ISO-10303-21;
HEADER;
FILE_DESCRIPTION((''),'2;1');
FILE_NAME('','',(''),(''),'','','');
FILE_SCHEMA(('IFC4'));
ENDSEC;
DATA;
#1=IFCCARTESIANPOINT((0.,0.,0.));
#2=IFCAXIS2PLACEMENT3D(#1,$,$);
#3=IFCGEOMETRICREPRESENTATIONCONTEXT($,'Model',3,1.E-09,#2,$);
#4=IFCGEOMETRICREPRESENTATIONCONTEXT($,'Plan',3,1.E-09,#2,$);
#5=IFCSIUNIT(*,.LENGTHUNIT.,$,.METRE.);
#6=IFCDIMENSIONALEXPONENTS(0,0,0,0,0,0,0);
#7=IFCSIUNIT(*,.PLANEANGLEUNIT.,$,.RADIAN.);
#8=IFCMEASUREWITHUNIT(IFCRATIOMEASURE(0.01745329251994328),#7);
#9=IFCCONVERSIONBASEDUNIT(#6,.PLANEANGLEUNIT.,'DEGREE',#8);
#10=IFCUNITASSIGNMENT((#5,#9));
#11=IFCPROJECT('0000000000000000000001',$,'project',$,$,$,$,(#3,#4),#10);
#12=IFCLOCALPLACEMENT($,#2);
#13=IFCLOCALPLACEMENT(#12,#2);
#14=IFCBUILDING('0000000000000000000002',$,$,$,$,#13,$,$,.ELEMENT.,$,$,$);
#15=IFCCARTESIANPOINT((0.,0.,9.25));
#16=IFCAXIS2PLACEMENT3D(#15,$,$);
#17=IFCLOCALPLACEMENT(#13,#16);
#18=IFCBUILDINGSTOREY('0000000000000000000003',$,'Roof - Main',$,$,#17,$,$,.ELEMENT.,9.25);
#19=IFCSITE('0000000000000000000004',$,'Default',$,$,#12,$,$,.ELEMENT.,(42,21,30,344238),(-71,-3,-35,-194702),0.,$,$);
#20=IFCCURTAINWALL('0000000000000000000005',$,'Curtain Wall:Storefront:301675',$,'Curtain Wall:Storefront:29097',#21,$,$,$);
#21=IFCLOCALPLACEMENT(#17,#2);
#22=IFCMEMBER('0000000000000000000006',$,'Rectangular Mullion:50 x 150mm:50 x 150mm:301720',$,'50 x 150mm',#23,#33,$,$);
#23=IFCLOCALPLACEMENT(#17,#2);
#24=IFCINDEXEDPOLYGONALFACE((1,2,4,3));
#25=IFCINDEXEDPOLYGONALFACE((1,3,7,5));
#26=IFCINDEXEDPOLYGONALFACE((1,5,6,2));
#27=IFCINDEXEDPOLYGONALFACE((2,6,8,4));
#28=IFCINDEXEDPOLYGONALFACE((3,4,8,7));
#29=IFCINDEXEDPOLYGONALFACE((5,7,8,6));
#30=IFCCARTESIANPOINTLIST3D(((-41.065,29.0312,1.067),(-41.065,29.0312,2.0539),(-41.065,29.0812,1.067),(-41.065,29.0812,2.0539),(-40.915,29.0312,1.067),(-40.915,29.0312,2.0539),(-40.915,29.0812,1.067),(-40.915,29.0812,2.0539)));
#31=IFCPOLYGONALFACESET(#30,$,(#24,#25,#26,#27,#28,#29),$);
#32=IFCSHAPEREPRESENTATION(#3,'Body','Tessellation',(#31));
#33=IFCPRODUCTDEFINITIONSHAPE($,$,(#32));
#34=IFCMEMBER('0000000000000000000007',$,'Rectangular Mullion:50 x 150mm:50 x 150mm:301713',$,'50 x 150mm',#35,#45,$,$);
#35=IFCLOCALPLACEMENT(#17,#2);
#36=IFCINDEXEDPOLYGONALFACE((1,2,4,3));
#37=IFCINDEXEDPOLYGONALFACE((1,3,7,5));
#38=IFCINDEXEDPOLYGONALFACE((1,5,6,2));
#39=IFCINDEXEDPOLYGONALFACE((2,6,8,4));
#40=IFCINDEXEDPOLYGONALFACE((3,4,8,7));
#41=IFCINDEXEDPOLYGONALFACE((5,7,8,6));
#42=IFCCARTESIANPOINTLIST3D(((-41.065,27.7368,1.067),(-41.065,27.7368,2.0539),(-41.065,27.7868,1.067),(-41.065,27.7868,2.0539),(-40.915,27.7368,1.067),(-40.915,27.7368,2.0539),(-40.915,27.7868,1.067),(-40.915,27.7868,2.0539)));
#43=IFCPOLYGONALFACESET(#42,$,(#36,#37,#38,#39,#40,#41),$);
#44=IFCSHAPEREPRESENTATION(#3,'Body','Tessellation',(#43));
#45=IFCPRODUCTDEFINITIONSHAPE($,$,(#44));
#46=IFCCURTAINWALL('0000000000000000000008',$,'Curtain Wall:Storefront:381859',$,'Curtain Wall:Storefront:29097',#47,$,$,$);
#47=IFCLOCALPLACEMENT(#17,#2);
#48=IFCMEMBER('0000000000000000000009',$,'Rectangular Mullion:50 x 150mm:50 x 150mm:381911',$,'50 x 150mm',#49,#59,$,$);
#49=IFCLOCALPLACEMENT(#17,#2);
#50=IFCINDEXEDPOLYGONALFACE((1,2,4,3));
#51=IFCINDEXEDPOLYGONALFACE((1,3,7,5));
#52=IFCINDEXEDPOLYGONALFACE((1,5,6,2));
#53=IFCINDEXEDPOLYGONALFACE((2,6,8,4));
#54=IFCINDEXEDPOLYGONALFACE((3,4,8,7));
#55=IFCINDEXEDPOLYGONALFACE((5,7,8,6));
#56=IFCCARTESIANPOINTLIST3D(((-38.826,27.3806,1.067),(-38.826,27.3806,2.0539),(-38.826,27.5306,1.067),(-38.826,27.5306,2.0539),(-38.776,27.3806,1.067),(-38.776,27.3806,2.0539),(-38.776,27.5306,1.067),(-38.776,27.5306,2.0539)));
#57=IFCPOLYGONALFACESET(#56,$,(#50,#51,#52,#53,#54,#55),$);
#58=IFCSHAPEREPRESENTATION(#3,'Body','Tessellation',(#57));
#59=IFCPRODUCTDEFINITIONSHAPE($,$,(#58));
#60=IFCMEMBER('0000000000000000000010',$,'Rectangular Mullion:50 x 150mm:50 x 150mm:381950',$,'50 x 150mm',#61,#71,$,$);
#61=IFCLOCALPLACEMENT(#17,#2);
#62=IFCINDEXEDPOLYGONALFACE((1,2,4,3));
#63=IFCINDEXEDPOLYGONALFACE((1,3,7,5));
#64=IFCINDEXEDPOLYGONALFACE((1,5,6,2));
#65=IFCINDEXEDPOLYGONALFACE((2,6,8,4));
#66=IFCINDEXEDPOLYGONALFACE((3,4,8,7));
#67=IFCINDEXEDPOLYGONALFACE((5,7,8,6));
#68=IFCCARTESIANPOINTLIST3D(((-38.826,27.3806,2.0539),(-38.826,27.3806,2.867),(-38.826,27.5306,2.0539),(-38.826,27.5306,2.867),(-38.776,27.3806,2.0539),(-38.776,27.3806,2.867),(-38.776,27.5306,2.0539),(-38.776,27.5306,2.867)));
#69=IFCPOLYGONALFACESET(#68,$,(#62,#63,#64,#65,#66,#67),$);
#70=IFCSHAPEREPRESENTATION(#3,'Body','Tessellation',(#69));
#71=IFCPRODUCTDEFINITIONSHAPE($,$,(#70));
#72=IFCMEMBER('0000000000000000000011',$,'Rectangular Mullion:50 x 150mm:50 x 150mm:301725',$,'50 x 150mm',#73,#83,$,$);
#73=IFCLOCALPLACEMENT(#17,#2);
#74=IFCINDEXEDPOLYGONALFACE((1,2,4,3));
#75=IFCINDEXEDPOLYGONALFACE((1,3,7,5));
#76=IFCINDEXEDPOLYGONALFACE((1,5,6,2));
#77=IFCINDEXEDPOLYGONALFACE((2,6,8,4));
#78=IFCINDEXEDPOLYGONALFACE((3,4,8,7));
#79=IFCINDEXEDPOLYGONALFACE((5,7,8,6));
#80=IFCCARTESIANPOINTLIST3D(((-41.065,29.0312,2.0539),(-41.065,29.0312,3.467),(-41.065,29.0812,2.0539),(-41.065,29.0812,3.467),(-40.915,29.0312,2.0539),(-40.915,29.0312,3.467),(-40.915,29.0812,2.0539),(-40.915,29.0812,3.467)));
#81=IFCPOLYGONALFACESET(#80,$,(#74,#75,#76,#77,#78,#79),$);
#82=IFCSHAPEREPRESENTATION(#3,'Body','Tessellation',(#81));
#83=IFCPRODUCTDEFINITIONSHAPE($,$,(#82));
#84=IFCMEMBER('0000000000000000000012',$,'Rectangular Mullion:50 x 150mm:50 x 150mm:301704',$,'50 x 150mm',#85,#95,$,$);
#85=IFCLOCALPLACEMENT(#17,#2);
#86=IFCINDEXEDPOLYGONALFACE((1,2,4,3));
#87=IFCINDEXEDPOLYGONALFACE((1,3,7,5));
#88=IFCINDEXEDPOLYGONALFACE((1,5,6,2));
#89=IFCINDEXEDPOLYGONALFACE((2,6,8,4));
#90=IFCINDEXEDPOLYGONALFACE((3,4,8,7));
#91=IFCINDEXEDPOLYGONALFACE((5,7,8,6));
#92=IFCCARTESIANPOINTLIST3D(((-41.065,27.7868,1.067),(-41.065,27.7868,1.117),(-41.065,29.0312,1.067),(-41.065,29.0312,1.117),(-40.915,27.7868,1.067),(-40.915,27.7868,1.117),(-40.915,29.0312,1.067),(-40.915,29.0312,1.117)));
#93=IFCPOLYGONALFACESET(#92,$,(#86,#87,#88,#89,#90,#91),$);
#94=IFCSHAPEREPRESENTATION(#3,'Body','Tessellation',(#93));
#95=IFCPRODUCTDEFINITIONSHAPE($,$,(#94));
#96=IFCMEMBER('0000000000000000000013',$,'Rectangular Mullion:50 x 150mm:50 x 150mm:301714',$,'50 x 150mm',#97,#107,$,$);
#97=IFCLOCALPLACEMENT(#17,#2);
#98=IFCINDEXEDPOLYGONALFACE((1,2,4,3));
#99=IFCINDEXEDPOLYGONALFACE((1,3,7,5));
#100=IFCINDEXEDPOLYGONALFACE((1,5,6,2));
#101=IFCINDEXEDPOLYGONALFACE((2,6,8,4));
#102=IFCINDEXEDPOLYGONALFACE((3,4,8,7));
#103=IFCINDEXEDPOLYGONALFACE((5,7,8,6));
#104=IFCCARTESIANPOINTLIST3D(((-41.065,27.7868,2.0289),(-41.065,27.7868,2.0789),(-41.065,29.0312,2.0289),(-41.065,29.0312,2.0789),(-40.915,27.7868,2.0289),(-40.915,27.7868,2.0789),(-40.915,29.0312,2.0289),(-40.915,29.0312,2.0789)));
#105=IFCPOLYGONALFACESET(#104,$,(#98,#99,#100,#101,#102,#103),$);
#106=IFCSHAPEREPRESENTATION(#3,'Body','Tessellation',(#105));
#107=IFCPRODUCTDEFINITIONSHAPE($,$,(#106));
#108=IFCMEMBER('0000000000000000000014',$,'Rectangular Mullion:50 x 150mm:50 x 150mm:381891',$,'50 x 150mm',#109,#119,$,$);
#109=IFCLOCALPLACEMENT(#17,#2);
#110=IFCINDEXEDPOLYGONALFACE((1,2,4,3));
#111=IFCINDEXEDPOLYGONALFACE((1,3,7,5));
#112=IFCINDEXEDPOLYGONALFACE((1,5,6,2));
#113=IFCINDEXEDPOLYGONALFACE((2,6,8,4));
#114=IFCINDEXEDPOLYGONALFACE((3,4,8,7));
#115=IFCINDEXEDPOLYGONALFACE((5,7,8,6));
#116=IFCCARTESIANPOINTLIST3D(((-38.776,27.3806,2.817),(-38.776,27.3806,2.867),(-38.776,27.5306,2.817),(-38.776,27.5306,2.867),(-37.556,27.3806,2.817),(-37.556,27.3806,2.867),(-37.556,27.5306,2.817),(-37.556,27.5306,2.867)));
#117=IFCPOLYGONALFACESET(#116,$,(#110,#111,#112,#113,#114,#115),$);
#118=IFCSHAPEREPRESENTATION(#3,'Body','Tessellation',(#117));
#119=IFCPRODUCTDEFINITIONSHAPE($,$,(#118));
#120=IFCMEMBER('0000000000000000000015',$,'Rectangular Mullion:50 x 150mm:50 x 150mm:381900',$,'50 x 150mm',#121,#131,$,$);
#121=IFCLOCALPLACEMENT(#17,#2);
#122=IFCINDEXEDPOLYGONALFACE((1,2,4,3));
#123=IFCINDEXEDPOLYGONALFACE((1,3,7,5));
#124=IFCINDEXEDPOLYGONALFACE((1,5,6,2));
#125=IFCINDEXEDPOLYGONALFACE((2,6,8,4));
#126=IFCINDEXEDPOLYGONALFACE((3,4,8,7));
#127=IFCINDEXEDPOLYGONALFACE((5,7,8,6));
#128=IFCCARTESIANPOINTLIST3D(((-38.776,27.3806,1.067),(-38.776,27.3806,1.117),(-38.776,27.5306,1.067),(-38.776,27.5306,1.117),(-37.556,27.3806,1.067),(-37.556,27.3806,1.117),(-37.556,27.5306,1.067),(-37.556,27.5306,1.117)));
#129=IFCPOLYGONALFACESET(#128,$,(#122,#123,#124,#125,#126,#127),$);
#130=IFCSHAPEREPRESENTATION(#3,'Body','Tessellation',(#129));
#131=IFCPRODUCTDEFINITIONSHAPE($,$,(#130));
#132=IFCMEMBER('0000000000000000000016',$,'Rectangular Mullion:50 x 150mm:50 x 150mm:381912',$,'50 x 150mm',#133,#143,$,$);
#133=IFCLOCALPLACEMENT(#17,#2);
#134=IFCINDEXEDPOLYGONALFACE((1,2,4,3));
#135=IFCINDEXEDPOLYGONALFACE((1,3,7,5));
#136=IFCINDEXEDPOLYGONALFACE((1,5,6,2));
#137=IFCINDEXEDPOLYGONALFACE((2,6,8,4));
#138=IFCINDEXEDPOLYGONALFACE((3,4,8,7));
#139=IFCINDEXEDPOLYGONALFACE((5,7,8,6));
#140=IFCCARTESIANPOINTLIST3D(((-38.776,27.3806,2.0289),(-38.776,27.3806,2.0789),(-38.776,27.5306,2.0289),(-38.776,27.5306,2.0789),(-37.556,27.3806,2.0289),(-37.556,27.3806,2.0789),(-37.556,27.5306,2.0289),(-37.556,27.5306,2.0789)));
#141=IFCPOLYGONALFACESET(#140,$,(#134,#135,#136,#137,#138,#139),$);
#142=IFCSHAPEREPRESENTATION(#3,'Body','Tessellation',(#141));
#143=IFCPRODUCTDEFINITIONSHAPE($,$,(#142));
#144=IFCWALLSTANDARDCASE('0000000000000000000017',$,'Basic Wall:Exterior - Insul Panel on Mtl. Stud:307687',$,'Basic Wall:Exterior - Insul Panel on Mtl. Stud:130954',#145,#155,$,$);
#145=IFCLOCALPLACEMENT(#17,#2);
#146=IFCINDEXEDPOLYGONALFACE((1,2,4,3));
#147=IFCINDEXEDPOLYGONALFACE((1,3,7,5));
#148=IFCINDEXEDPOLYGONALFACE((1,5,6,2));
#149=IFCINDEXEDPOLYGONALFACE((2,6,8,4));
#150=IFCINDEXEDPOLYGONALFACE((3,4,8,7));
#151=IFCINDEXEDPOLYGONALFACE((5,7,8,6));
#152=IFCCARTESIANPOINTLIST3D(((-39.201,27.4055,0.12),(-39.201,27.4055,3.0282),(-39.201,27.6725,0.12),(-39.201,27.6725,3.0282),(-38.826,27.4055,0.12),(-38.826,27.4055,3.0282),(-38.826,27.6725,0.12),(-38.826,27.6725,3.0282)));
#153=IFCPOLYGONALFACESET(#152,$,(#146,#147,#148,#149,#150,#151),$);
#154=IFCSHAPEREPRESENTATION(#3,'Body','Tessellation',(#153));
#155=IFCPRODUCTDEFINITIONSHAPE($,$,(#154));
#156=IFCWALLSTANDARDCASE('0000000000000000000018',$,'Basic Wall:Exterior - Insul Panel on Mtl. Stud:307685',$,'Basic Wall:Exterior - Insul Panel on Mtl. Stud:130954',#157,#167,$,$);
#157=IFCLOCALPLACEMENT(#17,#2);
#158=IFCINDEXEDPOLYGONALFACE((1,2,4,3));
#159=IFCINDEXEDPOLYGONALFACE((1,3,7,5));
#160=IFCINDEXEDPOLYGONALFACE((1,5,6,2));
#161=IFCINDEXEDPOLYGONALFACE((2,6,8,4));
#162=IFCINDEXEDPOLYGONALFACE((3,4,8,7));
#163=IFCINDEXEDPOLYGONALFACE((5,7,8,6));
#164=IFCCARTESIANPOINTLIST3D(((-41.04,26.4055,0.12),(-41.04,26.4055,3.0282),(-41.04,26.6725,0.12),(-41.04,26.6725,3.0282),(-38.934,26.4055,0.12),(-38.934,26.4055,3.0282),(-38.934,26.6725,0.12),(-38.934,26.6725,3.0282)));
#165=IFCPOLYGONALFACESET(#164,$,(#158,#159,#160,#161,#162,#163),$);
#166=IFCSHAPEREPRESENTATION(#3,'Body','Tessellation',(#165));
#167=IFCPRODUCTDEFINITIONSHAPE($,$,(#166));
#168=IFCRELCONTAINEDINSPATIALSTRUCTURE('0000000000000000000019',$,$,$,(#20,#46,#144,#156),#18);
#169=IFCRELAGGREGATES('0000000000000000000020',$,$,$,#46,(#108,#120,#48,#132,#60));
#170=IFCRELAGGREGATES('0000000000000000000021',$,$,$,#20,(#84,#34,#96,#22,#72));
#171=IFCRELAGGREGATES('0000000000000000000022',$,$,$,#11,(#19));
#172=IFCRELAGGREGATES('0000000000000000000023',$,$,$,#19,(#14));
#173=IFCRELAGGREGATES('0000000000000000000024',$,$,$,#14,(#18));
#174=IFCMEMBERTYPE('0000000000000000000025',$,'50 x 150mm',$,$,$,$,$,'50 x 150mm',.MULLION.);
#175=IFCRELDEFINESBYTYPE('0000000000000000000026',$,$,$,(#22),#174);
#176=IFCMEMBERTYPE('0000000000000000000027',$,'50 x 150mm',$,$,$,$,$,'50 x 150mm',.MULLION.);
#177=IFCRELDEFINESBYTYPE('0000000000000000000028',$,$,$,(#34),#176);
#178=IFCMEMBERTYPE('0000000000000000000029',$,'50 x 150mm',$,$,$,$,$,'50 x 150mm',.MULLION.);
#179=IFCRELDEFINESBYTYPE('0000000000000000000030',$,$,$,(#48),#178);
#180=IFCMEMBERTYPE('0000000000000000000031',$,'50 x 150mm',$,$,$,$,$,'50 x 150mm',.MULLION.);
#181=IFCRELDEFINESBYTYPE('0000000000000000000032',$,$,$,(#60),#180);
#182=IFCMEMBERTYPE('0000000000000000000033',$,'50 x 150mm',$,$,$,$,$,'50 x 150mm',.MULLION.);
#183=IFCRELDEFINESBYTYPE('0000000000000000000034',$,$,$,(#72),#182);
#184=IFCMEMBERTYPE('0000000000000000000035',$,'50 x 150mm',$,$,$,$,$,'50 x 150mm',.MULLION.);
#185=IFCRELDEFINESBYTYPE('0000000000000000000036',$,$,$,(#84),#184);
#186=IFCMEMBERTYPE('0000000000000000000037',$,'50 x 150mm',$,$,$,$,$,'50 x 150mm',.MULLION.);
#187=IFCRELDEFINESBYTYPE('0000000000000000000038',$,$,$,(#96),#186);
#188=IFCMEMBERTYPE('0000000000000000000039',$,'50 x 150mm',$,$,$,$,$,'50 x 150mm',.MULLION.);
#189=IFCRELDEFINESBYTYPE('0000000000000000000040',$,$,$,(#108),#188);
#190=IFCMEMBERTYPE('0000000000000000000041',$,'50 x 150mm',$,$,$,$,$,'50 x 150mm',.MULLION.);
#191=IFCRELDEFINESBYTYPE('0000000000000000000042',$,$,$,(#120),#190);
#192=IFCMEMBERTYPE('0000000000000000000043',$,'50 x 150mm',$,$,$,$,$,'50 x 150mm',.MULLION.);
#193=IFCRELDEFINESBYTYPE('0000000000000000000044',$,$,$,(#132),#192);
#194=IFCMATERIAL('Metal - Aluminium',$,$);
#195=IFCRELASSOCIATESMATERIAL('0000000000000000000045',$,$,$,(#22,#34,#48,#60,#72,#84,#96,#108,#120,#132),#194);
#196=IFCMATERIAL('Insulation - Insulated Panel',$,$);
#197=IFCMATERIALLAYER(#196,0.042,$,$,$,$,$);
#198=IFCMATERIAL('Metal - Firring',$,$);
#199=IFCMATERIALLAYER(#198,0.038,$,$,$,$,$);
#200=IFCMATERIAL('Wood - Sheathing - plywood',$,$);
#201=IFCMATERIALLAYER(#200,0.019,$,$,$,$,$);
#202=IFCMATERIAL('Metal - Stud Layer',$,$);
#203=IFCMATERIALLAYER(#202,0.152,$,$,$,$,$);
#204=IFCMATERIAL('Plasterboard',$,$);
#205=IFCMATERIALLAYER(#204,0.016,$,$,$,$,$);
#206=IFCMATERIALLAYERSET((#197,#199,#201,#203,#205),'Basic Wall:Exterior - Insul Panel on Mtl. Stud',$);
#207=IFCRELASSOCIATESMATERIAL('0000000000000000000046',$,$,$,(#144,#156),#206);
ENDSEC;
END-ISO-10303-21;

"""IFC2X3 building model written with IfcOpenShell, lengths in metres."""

from ifc_helpers import new_model, entity, si_unit, converted_unit, frame, frame_2d, origin, origin_2d_with_axis, place, context, project, spatial, rectangle, extrude, source, transform, mapped, material, layer, layer_set, layer_usage, type_object, type_shapes, element, aggregate, save


model = new_model("IFC2X3")

# Units and contexts
model_context = context("Model", 3, precision=1e-09, world=origin())
plan_context = context("Plan", 3, precision=1e-09, world=origin())
ifc_project = project(units=[si_unit("LENGTHUNIT", "METRE"), converted_unit("PLANEANGLEUNIT", "DEGREE", entity("IfcRatioMeasure", 0.01745329251994328), si_unit("PLANEANGLEUNIT", "RADIAN"), dimensions=[0, 0, 0, 0, 0, 0, 0])], contexts=[model_context, plan_context])

# Site, building, storey
site_placement = place(None, origin())
site = spatial("IfcSite", under=ifc_project, at=site_placement, Name="Default", CompositionType="ELEMENT", RefLatitude=(42, 21, 30, 344238), RefLongitude=(-71, -3, -35, -194702), RefElevation=0.0)
building_placement = place(site_placement, origin())
building = spatial("IfcBuilding", under=site, at=building_placement, CompositionType="ELEMENT")
storey_placement = place(building_placement, frame((0.0, 0.0, 9.25)))
storey = spatial("IfcBuildingStorey", under=building, at=storey_placement, Name="Roof - Main", CompositionType="ELEMENT", Elevation=9.25)

# Curtain walls, members
curtain_wall_1_placement = place(storey_placement, origin())
curtain_wall_1 = element("IfcCurtainWall", 1, at=curtain_wall_1_placement, inside=storey, Name="Curtain Wall:Storefront:301675", ObjectType="Curtain Wall:Storefront:29097")
ifc_material_1 = material(Name="Metal - Aluminium")
member_type_1 = type_object("IfcMemberType", Name="50 x 150mm", ElementType="50 x 150mm", PredefinedType="MULLION")
shared_shape_1 = source(origin(), model_context, "Body", "SweptSolid", [
    extrude(rectangle(XDim=0.05, YDim=0.15, at=origin_2d_with_axis()), frame((0.0, 0.0, -0.9869), z_axis=(0.0, 0.0, 1.0), x_axis=(-1.0, 0.0, 0.0)), (0.0, 0.0, 1.0), 0.9869),
])
type_shapes(member_type_1, [shared_shape_1])
member_1_placement = place(storey_placement, frame((-40.99, 29.0562, 1.067), z_axis=(0.0, 0.0, -1.0), x_axis=(0.0, 1.0, 0.0)))
member_1 = element("IfcMember", 2, at=member_1_placement, type_object=member_type_1, material=ifc_material_1, Name="Rectangular Mullion:50 x 150mm:50 x 150mm:301720", ObjectType="50 x 150mm", context=model_context, shape_type="MappedRepresentation", body=[
    mapped(shared_shape_1, transform((0.0, 0.0, 0.0), scale=1.0)),
])
member_type_2 = type_object("IfcMemberType", Name="50 x 150mm", ElementType="50 x 150mm", PredefinedType="MULLION")
shared_shape_2 = source(origin(), model_context, "Body", "SweptSolid", [
    extrude(rectangle(XDim=0.05, YDim=0.15, at=origin_2d_with_axis()), frame((-0.025, 0.0, -0.9869), z_axis=(0.0, 0.0, 1.0), x_axis=(-1.0, 0.0, 0.0)), (0.0, 0.0, 1.0), 0.9869),
])
type_shapes(member_type_2, [shared_shape_2])
member_2_placement = place(storey_placement, frame((-40.99, 27.7368, 2.0539), z_axis=(0.0, 0.0, 1.0), x_axis=(0.0, -1.0, 0.0)))
member_2 = element("IfcMember", 3, at=member_2_placement, type_object=member_type_2, material=ifc_material_1, Name="Rectangular Mullion:50 x 150mm:50 x 150mm:301713", ObjectType="50 x 150mm", context=model_context, shape_type="MappedRepresentation", body=[
    mapped(shared_shape_2, transform((0.0, 0.0, 0.0), scale=1.0)),
])
curtain_wall_2_placement = place(storey_placement, origin())
curtain_wall_2 = element("IfcCurtainWall", 4, at=curtain_wall_2_placement, inside=storey, Name="Curtain Wall:Storefront:381859", ObjectType="Curtain Wall:Storefront:29097")
member_type_3 = type_object("IfcMemberType", Name="50 x 150mm", ElementType="50 x 150mm", PredefinedType="MULLION")
type_shapes(member_type_3, [shared_shape_2])
member_3_placement = place(storey_placement, frame((-38.826, 27.4556, 2.0539), z_axis=(0.0, 0.0, 1.0), x_axis=(-1.0, 0.0, 0.0)))
member_3 = element("IfcMember", 5, at=member_3_placement, type_object=member_type_3, material=ifc_material_1, Name="Rectangular Mullion:50 x 150mm:50 x 150mm:381911", ObjectType="50 x 150mm", context=model_context, shape_type="MappedRepresentation", body=[
    mapped(shared_shape_2, transform((0.0, 0.0, 0.0), scale=1.0)),
])
member_type_4 = type_object("IfcMemberType", Name="50 x 150mm", ElementType="50 x 150mm", PredefinedType="MULLION")
shared_shape_3 = source(origin(), model_context, "Body", "SweptSolid", [
    extrude(rectangle(XDim=0.05, YDim=0.15, at=origin_2d_with_axis()), frame((-0.025, 0.0, -0.8131), z_axis=(0.0, 0.0, 1.0), x_axis=(-1.0, 0.0, 0.0)), (0.0, 0.0, 1.0), 0.8131),
])
type_shapes(member_type_4, [shared_shape_3])
member_4_placement = place(storey_placement, frame((-38.826, 27.4556, 2.867), z_axis=(0.0, 0.0, 1.0), x_axis=(-1.0, 0.0, 0.0)))
member_4 = element("IfcMember", 6, at=member_4_placement, type_object=member_type_4, material=ifc_material_1, Name="Rectangular Mullion:50 x 150mm:50 x 150mm:381950", ObjectType="50 x 150mm", context=model_context, shape_type="MappedRepresentation", body=[
    mapped(shared_shape_3, transform((0.0, 0.0, 0.0), scale=1.0)),
])

# Members
member_type_5 = type_object("IfcMemberType", Name="50 x 150mm", ElementType="50 x 150mm", PredefinedType="MULLION")
shared_shape_4 = source(origin(), model_context, "Body", "SweptSolid", [
    extrude(rectangle(XDim=0.05, YDim=0.15, at=origin_2d_with_axis()), frame((0.0, 0.0, -1.4131), z_axis=(0.0, 0.0, 1.0), x_axis=(-1.0, 0.0, 0.0)), (0.0, 0.0, 1.0), 1.4131),
])
type_shapes(member_type_5, [shared_shape_4])
member_5_placement = place(storey_placement, frame((-40.99, 29.0562, 2.0539), z_axis=(0.0, 0.0, -1.0), x_axis=(0.0, 1.0, 0.0)))
member_5 = element("IfcMember", 7, at=member_5_placement, type_object=member_type_5, material=ifc_material_1, Name="Rectangular Mullion:50 x 150mm:50 x 150mm:301725", ObjectType="50 x 150mm", context=model_context, shape_type="MappedRepresentation", body=[
    mapped(shared_shape_4, transform((0.0, 0.0, 0.0), scale=1.0)),
])
member_type_6 = type_object("IfcMemberType", Name="50 x 150mm", ElementType="50 x 150mm", PredefinedType="MULLION")
shared_shape_5 = source(origin(), model_context, "Body", "SweptSolid", [
    extrude(rectangle(XDim=0.05, YDim=0.15, at=origin_2d_with_axis()), frame((-0.025, 0.0, -1.2444), z_axis=(0.0, 0.0, 1.0), x_axis=(-1.0, 0.0, 0.0)), (0.0, 0.0, 1.0), 1.2444),
])
type_shapes(member_type_6, [shared_shape_5])
member_6_placement = place(storey_placement, frame((-40.99, 27.7868, 1.067), z_axis=(0.0, -1.0, 0.0), x_axis=(0.0, 0.0, -1.0)))
member_6 = element("IfcMember", 8, at=member_6_placement, type_object=member_type_6, material=ifc_material_1, Name="Rectangular Mullion:50 x 150mm:50 x 150mm:301704", ObjectType="50 x 150mm", context=model_context, shape_type="MappedRepresentation", body=[
    mapped(shared_shape_5, transform((0.0, 0.0, 0.0), scale=1.0)),
])
member_type_7 = type_object("IfcMemberType", Name="50 x 150mm", ElementType="50 x 150mm", PredefinedType="MULLION")
shared_shape_6 = source(origin(), model_context, "Body", "SweptSolid", [
    extrude(rectangle(XDim=0.05, YDim=0.15, at=origin_2d_with_axis()), frame((0.0, 0.0, -1.2444), z_axis=(0.0, 0.0, 1.0), x_axis=(-1.0, 0.0, 0.0)), (0.0, 0.0, 1.0), 1.2444),
])
type_shapes(member_type_7, [shared_shape_6])
member_7_placement = place(storey_placement, frame((-40.99, 29.0312, 2.0539), z_axis=(0.0, 1.0, 0.0), x_axis=(0.0, 0.0, 1.0)))
member_7 = element("IfcMember", 9, at=member_7_placement, type_object=member_type_7, material=ifc_material_1, Name="Rectangular Mullion:50 x 150mm:50 x 150mm:301714", ObjectType="50 x 150mm", context=model_context, shape_type="MappedRepresentation", body=[
    mapped(shared_shape_6, transform((0.0, 0.0, 0.0), scale=1.0)),
])
member_type_8 = type_object("IfcMemberType", Name="50 x 150mm", ElementType="50 x 150mm", PredefinedType="MULLION")
shared_shape_7 = source(origin(), model_context, "Body", "SweptSolid", [
    extrude(rectangle(XDim=0.05, YDim=0.15, at=origin_2d_with_axis()), frame((-0.025, 0.0, -1.22), z_axis=(0.0, 0.0, 1.0), x_axis=(-1.0, 0.0, 0.0)), (0.0, 0.0, 1.0), 1.22),
])
type_shapes(member_type_8, [shared_shape_7])
member_8_placement = place(storey_placement, frame((-37.556, 27.4556, 2.867), z_axis=(1.0, 0.0, 0.0), x_axis=(0.0, 0.0, 1.0)))
member_8 = element("IfcMember", 10, at=member_8_placement, type_object=member_type_8, material=ifc_material_1, Name="Rectangular Mullion:50 x 150mm:50 x 150mm:381891", ObjectType="50 x 150mm", context=model_context, shape_type="MappedRepresentation", body=[
    mapped(shared_shape_7, transform((0.0, 0.0, 0.0), scale=1.0)),
])
member_type_9 = type_object("IfcMemberType", Name="50 x 150mm", ElementType="50 x 150mm", PredefinedType="MULLION")
shared_shape_8 = source(origin(), model_context, "Body", "SweptSolid", [
    extrude(rectangle(XDim=0.05, YDim=0.15, at=origin_2d_with_axis()), frame((-0.025, 0.0, -1.22), z_axis=(0.0, 0.0, 1.0), x_axis=(-1.0, 0.0, 0.0)), (0.0, 0.0, 1.0), 1.22),
])
type_shapes(member_type_9, [shared_shape_8])
member_9_placement = place(storey_placement, frame((-38.776, 27.4556, 1.067), z_axis=(-1.0, 0.0, 0.0), x_axis=(0.0, 0.0, -1.0)))
member_9 = element("IfcMember", 11, at=member_9_placement, type_object=member_type_9, material=ifc_material_1, Name="Rectangular Mullion:50 x 150mm:50 x 150mm:381900", ObjectType="50 x 150mm", context=model_context, shape_type="MappedRepresentation", body=[
    mapped(shared_shape_8, transform((0.0, 0.0, 0.0), scale=1.0)),
])
member_type_10 = type_object("IfcMemberType", Name="50 x 150mm", ElementType="50 x 150mm", PredefinedType="MULLION")
shared_shape_9 = source(origin(), model_context, "Body", "SweptSolid", [
    extrude(rectangle(XDim=0.05, YDim=0.15, at=origin_2d_with_axis()), frame((0.0, 0.0, -1.22), z_axis=(0.0, 0.0, 1.0), x_axis=(-1.0, 0.0, 0.0)), (0.0, 0.0, 1.0), 1.22),
])
type_shapes(member_type_10, [shared_shape_9])
member_10_placement = place(storey_placement, frame((-37.556, 27.4556, 2.0539), z_axis=(1.0, 0.0, 0.0), x_axis=(0.0, 0.0, 1.0)))
member_10 = element("IfcMember", 12, at=member_10_placement, type_object=member_type_10, material=ifc_material_1, Name="Rectangular Mullion:50 x 150mm:50 x 150mm:381912", ObjectType="50 x 150mm", context=model_context, shape_type="MappedRepresentation", body=[
    mapped(shared_shape_9, transform((0.0, 0.0, 0.0), scale=1.0)),
])

aggregate(curtain_wall_2, [member_8, member_9, member_3, member_10, member_4])
aggregate(curtain_wall_1, [member_6, member_2, member_7, member_1, member_5])

# Shared definitions
ifc_material_2 = material(Name="Insulation - Insulated Panel")
ifc_layer_1 = layer(ifc_material_2, 0.042)
ifc_material_3 = material(Name="Metal - Firring")
ifc_layer_2 = layer(ifc_material_3, 0.038)
ifc_material_4 = material(Name="Wood - Sheathing - plywood")
ifc_layer_3 = layer(ifc_material_4, 0.019)
ifc_material_5 = material(Name="Metal - Stud Layer")
ifc_layer_4 = layer(ifc_material_5, 0.152)
ifc_material_6 = material(Name="Plasterboard")
ifc_layer_5 = layer(ifc_material_6, 0.016)
ifc_layer_set = layer_set([ifc_layer_1, ifc_layer_2, ifc_layer_3, ifc_layer_4, ifc_layer_5], Name="Basic Wall:Exterior - Insul Panel on Mtl. Stud")
ifc_layer_usage = layer_usage(ifc_layer_set, "AXIS2", "POSITIVE", -0.1335)

# Walls
wall_1_placement = place(storey_placement, frame((-39.201, 27.539, 0.12)))
element("IfcWallStandardCase", 13, at=wall_1_placement, inside=storey, material=ifc_layer_usage, Name="Basic Wall:Exterior - Insul Panel on Mtl. Stud:307687", ObjectType="Basic Wall:Exterior - Insul Panel on Mtl. Stud:130954", context=model_context, shape_type="SweptSolid", body=[
    extrude(rectangle(XDim=0.375, YDim=0.267, at=frame_2d((0.1875, 0.0), x_axis=(-1.0, 0.0))), origin(), (0.0, 0.0, 1.0), 2.9082),
])
wall_2_placement = place(storey_placement, frame((-41.04, 26.539, 0.12)))
element("IfcWallStandardCase", 14, at=wall_2_placement, inside=storey, material=ifc_layer_usage, Name="Basic Wall:Exterior - Insul Panel on Mtl. Stud:307685", ObjectType="Basic Wall:Exterior - Insul Panel on Mtl. Stud:130954", context=model_context, shape_type="SweptSolid", body=[
    extrude(rectangle(XDim=2.106, YDim=0.267, at=frame_2d((1.053, 0.0), x_axis=(-1.0, 0.0))), origin(), (0.0, 0.0, 1.0), 2.9082),
])

save(model, "model.ifc")
